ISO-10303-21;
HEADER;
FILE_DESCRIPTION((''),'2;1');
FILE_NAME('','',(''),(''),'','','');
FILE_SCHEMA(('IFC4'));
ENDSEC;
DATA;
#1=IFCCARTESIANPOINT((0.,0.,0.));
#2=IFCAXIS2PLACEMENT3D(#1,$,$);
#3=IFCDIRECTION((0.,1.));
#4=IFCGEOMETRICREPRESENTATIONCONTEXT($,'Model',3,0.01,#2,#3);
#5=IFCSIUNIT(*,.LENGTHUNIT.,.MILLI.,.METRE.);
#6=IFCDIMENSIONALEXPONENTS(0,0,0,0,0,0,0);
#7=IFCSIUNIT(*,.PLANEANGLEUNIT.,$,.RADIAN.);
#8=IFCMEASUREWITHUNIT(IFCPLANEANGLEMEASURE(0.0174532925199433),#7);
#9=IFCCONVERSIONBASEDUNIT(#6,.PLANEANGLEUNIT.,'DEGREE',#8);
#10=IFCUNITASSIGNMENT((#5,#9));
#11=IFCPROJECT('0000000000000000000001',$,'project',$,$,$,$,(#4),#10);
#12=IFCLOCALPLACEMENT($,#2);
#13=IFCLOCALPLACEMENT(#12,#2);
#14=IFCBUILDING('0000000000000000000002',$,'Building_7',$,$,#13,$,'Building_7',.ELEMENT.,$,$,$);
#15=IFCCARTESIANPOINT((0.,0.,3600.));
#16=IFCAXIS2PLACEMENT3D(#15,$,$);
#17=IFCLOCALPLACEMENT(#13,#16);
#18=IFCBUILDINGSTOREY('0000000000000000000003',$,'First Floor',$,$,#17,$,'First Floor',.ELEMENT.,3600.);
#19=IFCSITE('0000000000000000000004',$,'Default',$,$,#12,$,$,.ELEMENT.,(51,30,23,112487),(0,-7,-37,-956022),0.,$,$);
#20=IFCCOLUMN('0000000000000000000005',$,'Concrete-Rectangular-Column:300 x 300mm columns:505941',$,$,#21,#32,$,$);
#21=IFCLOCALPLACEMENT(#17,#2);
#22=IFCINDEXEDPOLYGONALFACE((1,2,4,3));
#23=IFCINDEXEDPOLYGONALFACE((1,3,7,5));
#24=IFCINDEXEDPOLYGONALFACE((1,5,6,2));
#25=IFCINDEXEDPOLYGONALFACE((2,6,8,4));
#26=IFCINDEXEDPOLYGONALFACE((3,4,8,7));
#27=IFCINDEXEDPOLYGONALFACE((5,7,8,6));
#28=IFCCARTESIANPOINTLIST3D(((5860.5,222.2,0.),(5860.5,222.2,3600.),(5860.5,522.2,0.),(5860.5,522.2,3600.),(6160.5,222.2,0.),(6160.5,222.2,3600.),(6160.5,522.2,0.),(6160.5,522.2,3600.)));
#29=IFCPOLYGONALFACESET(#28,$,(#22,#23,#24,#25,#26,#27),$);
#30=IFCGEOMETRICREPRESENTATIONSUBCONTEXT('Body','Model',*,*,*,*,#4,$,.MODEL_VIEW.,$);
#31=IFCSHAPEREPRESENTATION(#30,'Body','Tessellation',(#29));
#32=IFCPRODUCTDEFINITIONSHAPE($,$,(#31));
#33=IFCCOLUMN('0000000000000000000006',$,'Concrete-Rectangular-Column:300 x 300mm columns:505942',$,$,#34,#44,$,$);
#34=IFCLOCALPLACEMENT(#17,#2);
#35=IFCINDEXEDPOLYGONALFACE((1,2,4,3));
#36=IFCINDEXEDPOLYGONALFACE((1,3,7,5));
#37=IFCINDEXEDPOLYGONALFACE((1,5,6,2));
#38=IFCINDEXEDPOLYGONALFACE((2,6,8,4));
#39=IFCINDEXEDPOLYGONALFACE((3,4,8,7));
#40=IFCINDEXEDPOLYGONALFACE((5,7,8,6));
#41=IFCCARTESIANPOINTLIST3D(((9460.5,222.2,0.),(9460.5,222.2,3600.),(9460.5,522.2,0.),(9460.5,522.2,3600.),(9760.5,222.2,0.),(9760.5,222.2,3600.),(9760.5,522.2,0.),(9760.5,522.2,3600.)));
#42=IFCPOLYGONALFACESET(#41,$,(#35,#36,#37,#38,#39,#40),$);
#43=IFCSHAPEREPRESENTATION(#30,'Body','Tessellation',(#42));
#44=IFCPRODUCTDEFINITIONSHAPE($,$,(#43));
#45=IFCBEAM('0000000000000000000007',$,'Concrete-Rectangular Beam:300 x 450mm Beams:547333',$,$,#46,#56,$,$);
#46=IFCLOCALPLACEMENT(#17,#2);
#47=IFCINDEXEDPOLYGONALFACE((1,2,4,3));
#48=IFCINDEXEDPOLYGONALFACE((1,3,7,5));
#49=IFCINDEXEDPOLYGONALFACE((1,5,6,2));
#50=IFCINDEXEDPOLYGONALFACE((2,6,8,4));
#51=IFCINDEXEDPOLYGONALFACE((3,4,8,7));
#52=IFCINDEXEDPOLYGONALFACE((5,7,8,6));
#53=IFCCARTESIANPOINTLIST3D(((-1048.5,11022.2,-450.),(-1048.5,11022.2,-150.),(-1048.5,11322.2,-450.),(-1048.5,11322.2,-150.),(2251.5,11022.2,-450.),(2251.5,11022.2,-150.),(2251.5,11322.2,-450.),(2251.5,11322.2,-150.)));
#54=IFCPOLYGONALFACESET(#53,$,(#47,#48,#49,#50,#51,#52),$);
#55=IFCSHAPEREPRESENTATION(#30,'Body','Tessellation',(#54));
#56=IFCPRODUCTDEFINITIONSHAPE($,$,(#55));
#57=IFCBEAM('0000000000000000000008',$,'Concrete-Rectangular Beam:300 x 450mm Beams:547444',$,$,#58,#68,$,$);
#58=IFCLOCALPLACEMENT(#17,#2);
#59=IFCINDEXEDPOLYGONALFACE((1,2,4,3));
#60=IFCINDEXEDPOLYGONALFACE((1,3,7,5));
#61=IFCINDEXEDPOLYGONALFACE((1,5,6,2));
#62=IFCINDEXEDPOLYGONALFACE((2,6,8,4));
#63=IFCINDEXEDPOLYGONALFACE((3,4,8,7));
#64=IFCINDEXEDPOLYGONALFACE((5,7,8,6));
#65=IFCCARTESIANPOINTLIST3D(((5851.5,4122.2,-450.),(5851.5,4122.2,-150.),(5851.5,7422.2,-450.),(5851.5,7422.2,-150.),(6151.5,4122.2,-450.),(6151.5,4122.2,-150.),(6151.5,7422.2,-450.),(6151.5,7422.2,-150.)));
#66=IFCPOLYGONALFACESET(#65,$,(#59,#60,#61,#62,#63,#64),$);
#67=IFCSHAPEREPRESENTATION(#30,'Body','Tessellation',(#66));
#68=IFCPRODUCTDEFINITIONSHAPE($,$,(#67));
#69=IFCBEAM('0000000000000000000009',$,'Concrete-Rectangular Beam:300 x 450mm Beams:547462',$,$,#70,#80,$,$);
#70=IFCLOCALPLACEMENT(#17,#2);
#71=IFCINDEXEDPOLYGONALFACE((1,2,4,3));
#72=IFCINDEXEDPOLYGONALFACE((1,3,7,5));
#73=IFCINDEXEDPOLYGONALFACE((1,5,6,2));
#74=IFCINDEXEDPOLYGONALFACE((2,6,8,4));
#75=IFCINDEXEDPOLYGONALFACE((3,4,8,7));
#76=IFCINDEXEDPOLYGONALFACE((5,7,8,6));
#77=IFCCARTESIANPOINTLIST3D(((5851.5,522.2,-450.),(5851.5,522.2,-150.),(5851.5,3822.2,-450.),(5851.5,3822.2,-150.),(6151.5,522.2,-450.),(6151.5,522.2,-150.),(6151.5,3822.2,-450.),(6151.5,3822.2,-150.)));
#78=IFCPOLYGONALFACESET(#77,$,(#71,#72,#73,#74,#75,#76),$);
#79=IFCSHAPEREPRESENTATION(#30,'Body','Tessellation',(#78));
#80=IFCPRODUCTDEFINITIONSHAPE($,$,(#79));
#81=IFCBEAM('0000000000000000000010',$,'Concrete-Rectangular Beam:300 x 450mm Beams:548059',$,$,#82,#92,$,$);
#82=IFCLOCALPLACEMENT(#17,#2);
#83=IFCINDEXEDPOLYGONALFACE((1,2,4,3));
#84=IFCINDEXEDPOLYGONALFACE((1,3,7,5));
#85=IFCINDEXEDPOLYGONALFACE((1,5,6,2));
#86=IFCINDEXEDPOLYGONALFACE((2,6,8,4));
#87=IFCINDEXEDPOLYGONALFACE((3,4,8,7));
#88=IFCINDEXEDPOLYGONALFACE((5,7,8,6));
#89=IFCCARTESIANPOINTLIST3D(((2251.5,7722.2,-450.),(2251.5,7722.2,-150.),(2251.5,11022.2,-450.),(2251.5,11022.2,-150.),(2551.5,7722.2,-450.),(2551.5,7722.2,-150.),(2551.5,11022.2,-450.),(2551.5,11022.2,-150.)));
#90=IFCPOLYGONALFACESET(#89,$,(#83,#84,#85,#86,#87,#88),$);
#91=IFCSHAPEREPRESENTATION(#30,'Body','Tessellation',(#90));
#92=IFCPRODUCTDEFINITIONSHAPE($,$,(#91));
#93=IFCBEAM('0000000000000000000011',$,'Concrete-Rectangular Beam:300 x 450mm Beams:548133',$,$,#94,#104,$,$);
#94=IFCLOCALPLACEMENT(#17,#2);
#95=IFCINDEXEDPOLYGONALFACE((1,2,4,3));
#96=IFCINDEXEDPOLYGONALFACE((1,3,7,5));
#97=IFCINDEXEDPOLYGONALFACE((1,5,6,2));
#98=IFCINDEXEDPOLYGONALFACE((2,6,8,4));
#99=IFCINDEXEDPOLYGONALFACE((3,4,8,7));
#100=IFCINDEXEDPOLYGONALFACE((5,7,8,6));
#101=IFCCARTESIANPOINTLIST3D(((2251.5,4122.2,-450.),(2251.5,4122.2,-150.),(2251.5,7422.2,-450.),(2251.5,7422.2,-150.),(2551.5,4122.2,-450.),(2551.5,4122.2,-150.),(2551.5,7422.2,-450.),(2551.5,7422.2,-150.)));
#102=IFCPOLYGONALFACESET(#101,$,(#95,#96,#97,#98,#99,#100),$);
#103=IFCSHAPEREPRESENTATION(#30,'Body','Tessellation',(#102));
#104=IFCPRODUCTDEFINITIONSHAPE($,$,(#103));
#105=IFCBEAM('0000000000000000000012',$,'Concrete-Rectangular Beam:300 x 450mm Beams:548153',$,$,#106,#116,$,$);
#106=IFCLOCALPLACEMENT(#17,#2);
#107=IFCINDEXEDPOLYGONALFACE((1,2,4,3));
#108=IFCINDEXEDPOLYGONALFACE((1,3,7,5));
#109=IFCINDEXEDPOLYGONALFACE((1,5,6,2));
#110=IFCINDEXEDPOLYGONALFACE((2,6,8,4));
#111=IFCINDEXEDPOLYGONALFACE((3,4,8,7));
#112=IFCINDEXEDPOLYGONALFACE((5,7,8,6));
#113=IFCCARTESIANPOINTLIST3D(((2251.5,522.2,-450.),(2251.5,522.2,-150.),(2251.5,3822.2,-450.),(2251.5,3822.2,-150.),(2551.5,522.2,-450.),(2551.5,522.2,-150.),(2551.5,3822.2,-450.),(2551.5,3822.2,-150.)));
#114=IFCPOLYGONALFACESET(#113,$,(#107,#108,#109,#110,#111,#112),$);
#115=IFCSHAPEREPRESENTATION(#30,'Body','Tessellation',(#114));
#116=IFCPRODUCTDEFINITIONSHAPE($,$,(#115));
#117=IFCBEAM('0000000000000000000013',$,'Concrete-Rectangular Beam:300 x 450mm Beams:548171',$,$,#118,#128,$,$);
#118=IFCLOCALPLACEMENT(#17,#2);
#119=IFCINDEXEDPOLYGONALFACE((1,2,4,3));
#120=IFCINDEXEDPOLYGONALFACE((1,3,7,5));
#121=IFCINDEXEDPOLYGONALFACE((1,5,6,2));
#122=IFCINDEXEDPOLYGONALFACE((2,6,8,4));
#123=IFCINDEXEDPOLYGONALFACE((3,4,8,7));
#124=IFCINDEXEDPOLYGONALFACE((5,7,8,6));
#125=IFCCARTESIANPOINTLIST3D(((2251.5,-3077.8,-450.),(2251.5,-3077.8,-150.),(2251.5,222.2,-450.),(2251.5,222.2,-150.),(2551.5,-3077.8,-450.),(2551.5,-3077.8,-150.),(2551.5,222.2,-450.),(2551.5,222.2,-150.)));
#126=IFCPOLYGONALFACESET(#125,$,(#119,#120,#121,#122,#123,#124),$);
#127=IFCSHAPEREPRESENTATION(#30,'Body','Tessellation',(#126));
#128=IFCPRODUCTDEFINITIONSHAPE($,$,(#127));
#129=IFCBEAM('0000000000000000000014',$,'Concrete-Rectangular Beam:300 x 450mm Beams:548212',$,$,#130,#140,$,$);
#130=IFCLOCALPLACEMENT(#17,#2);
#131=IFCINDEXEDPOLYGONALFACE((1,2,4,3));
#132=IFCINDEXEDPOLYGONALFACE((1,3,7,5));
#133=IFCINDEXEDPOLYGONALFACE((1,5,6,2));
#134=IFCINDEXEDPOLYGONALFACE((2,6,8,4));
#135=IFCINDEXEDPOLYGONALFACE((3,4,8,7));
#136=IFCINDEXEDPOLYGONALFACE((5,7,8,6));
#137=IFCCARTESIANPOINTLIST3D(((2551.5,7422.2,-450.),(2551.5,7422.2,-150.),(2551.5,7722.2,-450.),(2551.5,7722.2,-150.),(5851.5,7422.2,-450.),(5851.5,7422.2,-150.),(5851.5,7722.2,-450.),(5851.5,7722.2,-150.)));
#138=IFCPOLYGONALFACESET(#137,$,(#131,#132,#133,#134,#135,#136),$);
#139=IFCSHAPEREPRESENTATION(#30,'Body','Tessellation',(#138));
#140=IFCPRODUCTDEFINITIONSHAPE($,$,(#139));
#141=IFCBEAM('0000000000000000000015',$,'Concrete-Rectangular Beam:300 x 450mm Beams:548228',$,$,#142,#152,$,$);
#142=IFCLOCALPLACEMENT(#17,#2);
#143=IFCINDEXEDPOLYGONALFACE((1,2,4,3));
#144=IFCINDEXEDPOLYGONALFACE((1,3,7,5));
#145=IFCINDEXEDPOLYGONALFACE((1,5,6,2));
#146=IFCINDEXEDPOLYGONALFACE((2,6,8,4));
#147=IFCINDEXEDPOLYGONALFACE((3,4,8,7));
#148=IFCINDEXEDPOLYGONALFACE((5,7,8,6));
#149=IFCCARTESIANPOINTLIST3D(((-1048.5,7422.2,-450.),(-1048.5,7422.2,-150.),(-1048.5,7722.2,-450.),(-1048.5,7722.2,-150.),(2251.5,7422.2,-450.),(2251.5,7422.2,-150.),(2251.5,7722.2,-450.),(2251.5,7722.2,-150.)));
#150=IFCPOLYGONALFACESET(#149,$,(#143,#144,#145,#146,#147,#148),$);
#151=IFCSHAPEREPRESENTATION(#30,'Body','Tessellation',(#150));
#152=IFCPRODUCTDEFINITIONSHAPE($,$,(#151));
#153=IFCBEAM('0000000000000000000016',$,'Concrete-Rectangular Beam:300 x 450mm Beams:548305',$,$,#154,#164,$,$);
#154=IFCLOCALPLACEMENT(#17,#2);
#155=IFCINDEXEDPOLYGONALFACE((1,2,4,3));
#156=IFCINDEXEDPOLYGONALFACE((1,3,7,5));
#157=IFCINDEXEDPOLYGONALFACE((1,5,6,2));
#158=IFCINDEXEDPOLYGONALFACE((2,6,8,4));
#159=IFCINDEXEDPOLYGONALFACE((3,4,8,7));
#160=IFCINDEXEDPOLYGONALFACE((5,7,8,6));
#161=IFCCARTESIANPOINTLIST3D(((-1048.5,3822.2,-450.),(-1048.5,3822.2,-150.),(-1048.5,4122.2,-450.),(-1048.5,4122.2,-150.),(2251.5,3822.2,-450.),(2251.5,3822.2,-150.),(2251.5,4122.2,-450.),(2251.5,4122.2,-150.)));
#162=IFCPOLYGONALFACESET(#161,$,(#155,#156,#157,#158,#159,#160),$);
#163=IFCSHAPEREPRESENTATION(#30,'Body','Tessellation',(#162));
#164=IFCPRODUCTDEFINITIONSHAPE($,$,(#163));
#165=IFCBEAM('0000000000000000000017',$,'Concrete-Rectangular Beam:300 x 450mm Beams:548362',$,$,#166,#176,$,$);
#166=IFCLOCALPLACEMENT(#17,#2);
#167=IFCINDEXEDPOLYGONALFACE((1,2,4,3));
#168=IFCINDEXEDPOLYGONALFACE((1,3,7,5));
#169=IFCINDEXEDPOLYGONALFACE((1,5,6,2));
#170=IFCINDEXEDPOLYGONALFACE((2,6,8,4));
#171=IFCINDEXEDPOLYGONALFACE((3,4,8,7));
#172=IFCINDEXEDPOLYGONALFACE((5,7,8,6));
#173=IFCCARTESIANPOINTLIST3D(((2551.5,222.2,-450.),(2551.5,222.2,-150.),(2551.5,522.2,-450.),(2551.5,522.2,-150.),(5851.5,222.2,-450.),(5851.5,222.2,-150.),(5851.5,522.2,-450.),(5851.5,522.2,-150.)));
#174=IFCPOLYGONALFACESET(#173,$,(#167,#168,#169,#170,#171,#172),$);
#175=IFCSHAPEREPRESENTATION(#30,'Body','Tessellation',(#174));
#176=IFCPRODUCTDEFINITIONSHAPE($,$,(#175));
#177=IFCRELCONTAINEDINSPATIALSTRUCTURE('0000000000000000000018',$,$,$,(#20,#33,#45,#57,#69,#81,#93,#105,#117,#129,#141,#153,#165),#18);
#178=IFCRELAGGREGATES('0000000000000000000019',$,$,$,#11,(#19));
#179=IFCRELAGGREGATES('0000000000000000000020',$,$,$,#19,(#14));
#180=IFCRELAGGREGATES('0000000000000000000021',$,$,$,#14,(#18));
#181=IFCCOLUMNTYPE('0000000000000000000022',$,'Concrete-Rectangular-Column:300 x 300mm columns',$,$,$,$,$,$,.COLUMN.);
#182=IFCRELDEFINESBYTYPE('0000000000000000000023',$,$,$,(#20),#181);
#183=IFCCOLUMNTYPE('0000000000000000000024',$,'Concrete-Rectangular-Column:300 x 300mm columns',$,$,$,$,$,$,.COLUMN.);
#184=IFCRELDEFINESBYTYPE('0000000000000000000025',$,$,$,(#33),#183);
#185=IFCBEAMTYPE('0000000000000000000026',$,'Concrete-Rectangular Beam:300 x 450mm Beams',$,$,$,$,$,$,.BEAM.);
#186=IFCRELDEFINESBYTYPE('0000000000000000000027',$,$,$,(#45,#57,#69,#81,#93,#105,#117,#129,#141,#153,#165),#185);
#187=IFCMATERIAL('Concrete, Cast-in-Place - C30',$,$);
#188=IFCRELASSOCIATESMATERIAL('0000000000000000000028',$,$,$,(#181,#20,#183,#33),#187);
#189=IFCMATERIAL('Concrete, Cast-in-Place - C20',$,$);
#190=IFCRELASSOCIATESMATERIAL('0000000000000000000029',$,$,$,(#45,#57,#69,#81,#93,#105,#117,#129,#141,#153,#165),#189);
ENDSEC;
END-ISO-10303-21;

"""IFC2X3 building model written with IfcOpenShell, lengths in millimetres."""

from ifc_helpers import new_model, entity, si_unit, converted_unit, direction, frame, frame_2d, origin, origin_2d_with_axis, place, context, subcontext, project, spatial, rectangle, extrude, source, transform, mapped, material, type_object, type_shapes, element, save


model = new_model("IFC2X3")

# Units and contexts
model_context = context("Model", 3, precision=0.01, world=origin(), true_north=direction((0.0, 1.0)))
body_context = subcontext(model_context, "Body", "Model", "MODEL_VIEW")
ifc_project = project(units=[si_unit("LENGTHUNIT", "METRE", prefix="MILLI"), converted_unit("PLANEANGLEUNIT", "DEGREE", entity("IfcPlaneAngleMeasure", 0.0174532925199433), si_unit("PLANEANGLEUNIT", "RADIAN"), dimensions=[0, 0, 0, 0, 0, 0, 0])], contexts=[model_context])

# Site, building, storey
site_placement = place(None, origin())
site = spatial("IfcSite", under=ifc_project, at=site_placement, Name="Default", CompositionType="ELEMENT", RefLatitude=(51, 30, 23, 112487), RefLongitude=(0, -7, -37, -956022), RefElevation=0.0)
building_placement = place(site_placement, origin())
building = spatial("IfcBuilding", under=site, at=building_placement, Name="Building_7", LongName="Building_7", CompositionType="ELEMENT")
storey_placement = place(building_placement, frame((0.0, 0.0, 3600.0)))
storey = spatial("IfcBuildingStorey", under=building, at=storey_placement, Name="First Floor", LongName="First Floor", CompositionType="ELEMENT", Elevation=3600.0)

# Shared definitions
ifc_material_1 = material(Name="Concrete, Cast-in-Place - C30")

# Columns
column_type_1 = type_object("IfcColumnType", Name="Concrete-Rectangular-Column:300 x 300mm columns", PredefinedType="COLUMN", material=ifc_material_1)
shared_shape_1 = source(origin(), body_context, "Body", "SweptSolid", [
    extrude(rectangle(XDim=300.0, YDim=300.0, at=frame_2d((0.0, 0.0), x_axis=(1.0, 0.0))), frame((6010.5, 372.2, 3600.0), z_axis=(0.0, 0.0, 1.0), x_axis=(-1.0, 0.0, 0.0)), (0.0, 0.0, 1.0), 3600.0),
])
type_shapes(column_type_1, [shared_shape_1])
column_1_placement = place(storey_placement, frame((0.0, 0.0, -3600.0)))
element("IfcColumn", 1, at=column_1_placement, inside=storey, type_object=column_type_1, material=ifc_material_1, Name="Concrete-Rectangular-Column:300 x 300mm columns:505941", context=body_context, shape_type="MappedRepresentation", body=[
    mapped(shared_shape_1, transform((0.0, 0.0, 0.0), scale=1.0)),
])
column_type_2 = type_object("IfcColumnType", Name="Concrete-Rectangular-Column:300 x 300mm columns", PredefinedType="COLUMN", material=ifc_material_1)
shared_shape_2 = source(origin(), body_context, "Body", "SweptSolid", [
    extrude(rectangle(XDim=300.0, YDim=300.0, at=frame_2d((0.0, 0.0), x_axis=(1.0, 0.0))), frame((9610.5, 372.2, 3600.0), z_axis=(0.0, 0.0, 1.0), x_axis=(-1.0, 0.0, 0.0)), (0.0, 0.0, 1.0), 3600.0),
])
type_shapes(column_type_2, [shared_shape_2])
column_2_placement = place(storey_placement, frame((0.0, 0.0, -3600.0)))
element("IfcColumn", 2, at=column_2_placement, inside=storey, type_object=column_type_2, material=ifc_material_1, Name="Concrete-Rectangular-Column:300 x 300mm columns:505942", context=body_context, shape_type="MappedRepresentation", body=[
    mapped(shared_shape_2, transform((0.0, 0.0, 0.0), scale=1.0)),
])

# Beams
ifc_material_2 = material(Name="Concrete, Cast-in-Place - C20")
beam_type_1 = type_object("IfcBeamType", Name="Concrete-Rectangular Beam:300 x 450mm Beams", PredefinedType="BEAM")
beam_1_placement = place(storey_placement, frame((2401.5, 11172.2, 0.0), z_axis=(0.0, 0.0, 1.0), x_axis=(-1.0, 0.0, 0.0)))
element("IfcBeam", 3, at=beam_1_placement, inside=storey, type_object=beam_type_1, material=ifc_material_2, Name="Concrete-Rectangular Beam:300 x 450mm Beams:547333", context=body_context, shape_type="SweptSolid", body=[
    extrude(rectangle(XDim=300.0, YDim=300.0, at=frame_2d((0.0, 0.0), x_axis=(1.0, 0.0))), frame((150.0, 0.0, -300.0), z_axis=(1.0, 0.0, 0.0), x_axis=(0.0, 0.0, -1.0)), (0.0, 0.0, 1.0), 3300.0),
])
beam_2_placement = place(storey_placement, frame((6001.5, 7572.2, 0.0), z_axis=(0.0, 0.0, 1.0), x_axis=(0.0, -1.0, 0.0)))
element("IfcBeam", 4, at=beam_2_placement, inside=storey, type_object=beam_type_1, material=ifc_material_2, Name="Concrete-Rectangular Beam:300 x 450mm Beams:547444", context=body_context, shape_type="SweptSolid", body=[
    extrude(rectangle(XDim=300.0, YDim=300.0, at=origin_2d_with_axis()), frame((150.0, 0.0, -300.0), z_axis=(1.0, 0.0, 0.0), x_axis=(0.0, 0.0, -1.0)), (0.0, 0.0, 1.0), 3300.0),
])
beam_3_placement = place(storey_placement, frame((6001.5, 3972.2, 0.0), z_axis=(0.0, 0.0, 1.0), x_axis=(0.0, -1.0, 0.0)))
element("IfcBeam", 5, at=beam_3_placement, inside=storey, type_object=beam_type_1, material=ifc_material_2, Name="Concrete-Rectangular Beam:300 x 450mm Beams:547462", context=body_context, shape_type="SweptSolid", body=[
    extrude(rectangle(XDim=300.0, YDim=300.0, at=origin_2d_with_axis()), frame((150.0, 0.0, -300.0), z_axis=(1.0, 0.0, 0.0), x_axis=(0.0, 0.0, -1.0)), (0.0, 0.0, 1.0), 3300.0),
])
beam_4_placement = place(storey_placement, frame((2401.5, 11172.2, 0.0), z_axis=(0.0, 0.0, 1.0), x_axis=(0.0, -1.0, 0.0)))
element("IfcBeam", 6, at=beam_4_placement, inside=storey, type_object=beam_type_1, material=ifc_material_2, Name="Concrete-Rectangular Beam:300 x 450mm Beams:548059", context=body_context, shape_type="SweptSolid", body=[
    extrude(rectangle(XDim=300.0, YDim=300.0, at=origin_2d_with_axis()), frame((150.0, 0.0, -300.0), z_axis=(1.0, 0.0, 0.0), x_axis=(0.0, 0.0, -1.0)), (0.0, 0.0, 1.0), 3300.0),
])
beam_5_placement = place(storey_placement, frame((2401.5, 7572.2, 0.0), z_axis=(0.0, 0.0, 1.0), x_axis=(0.0, -1.0, 0.0)))
element("IfcBeam", 7, at=beam_5_placement, inside=storey, type_object=beam_type_1, material=ifc_material_2, Name="Concrete-Rectangular Beam:300 x 450mm Beams:548133", context=body_context, shape_type="SweptSolid", body=[
    extrude(rectangle(XDim=300.0, YDim=300.0, at=frame_2d((0.0, 0.0), x_axis=(1.0, 0.0))), frame((150.0, 0.0, -300.0), z_axis=(1.0, 0.0, 0.0), x_axis=(0.0, 0.0, -1.0)), (0.0, 0.0, 1.0), 3300.0),
])
beam_6_placement = place(storey_placement, frame((2401.5, 3972.2, 0.0), z_axis=(0.0, 0.0, 1.0), x_axis=(0.0, -1.0, 0.0)))
element("IfcBeam", 8, at=beam_6_placement, inside=storey, type_object=beam_type_1, material=ifc_material_2, Name="Concrete-Rectangular Beam:300 x 450mm Beams:548153", context=body_context, shape_type="SweptSolid", body=[
    extrude(rectangle(XDim=300.0, YDim=300.0, at=frame_2d((0.0, 0.0), x_axis=(1.0, 0.0))), frame((150.0, 0.0, -300.0), z_axis=(1.0, 0.0, 0.0), x_axis=(0.0, 0.0, -1.0)), (0.0, 0.0, 1.0), 3300.0),
])
beam_7_placement = place(storey_placement, frame((2401.5, 372.2, 0.0), z_axis=(0.0, 0.0, 1.0), x_axis=(0.0, -1.0, 0.0)))
element("IfcBeam", 9, at=beam_7_placement, inside=storey, type_object=beam_type_1, material=ifc_material_2, Name="Concrete-Rectangular Beam:300 x 450mm Beams:548171", context=body_context, shape_type="SweptSolid", body=[
    extrude(rectangle(XDim=300.0, YDim=300.0, at=frame_2d((0.0, 0.0), x_axis=(1.0, 0.0))), frame((150.0, 0.0, -300.0), z_axis=(1.0, 0.0, 0.0), x_axis=(0.0, 0.0, -1.0)), (0.0, 0.0, 1.0), 3300.0),
])
beam_8_placement = place(storey_placement, frame((6001.5, 7572.2, 0.0), z_axis=(0.0, 0.0, 1.0), x_axis=(-1.0, 0.0, 0.0)))
element("IfcBeam", 10, at=beam_8_placement, inside=storey, type_object=beam_type_1, material=ifc_material_2, Name="Concrete-Rectangular Beam:300 x 450mm Beams:548212", context=body_context, shape_type="SweptSolid", body=[
    extrude(rectangle(XDim=300.0, YDim=300.0, at=frame_2d((0.0, 0.0), x_axis=(1.0, 0.0))), frame((150.0, 0.0, -300.0), z_axis=(1.0, 0.0, 0.0), x_axis=(0.0, 0.0, -1.0)), (0.0, 0.0, 1.0), 3300.0),
])
beam_9_placement = place(storey_placement, frame((2401.5, 7572.2, 0.0), z_axis=(0.0, 0.0, 1.0), x_axis=(-1.0, 0.0, 0.0)))
element("IfcBeam", 11, at=beam_9_placement, inside=storey, type_object=beam_type_1, material=ifc_material_2, Name="Concrete-Rectangular Beam:300 x 450mm Beams:548228", context=body_context, shape_type="SweptSolid", body=[
    extrude(rectangle(XDim=300.0, YDim=300.0, at=frame_2d((0.0, 0.0), x_axis=(1.0, 0.0))), frame((150.0, 0.0, -300.0), z_axis=(1.0, 0.0, 0.0), x_axis=(0.0, 0.0, -1.0)), (0.0, 0.0, 1.0), 3300.0),
])
beam_10_placement = place(storey_placement, frame((2401.5, 3972.2, 0.0), z_axis=(0.0, 0.0, 1.0), x_axis=(-1.0, 0.0, 0.0)))
element("IfcBeam", 12, at=beam_10_placement, inside=storey, type_object=beam_type_1, material=ifc_material_2, Name="Concrete-Rectangular Beam:300 x 450mm Beams:548305", context=body_context, shape_type="SweptSolid", body=[
    extrude(rectangle(XDim=300.0, YDim=300.0, at=frame_2d((0.0, 0.0), x_axis=(1.0, 0.0))), frame((150.0, 0.0, -300.0), z_axis=(1.0, 0.0, 0.0), x_axis=(0.0, 0.0, -1.0)), (0.0, 0.0, 1.0), 3300.0),
])
beam_11_placement = place(storey_placement, frame((6001.5, 372.2, 0.0), z_axis=(0.0, 0.0, 1.0), x_axis=(-1.0, 0.0, 0.0)))
element("IfcBeam", 13, at=beam_11_placement, inside=storey, type_object=beam_type_1, material=ifc_material_2, Name="Concrete-Rectangular Beam:300 x 450mm Beams:548362", context=body_context, shape_type="SweptSolid", body=[
    extrude(rectangle(XDim=300.0, YDim=300.0, at=frame_2d((0.0, 0.0), x_axis=(1.0, 0.0))), frame((150.0, 0.0, -300.0), z_axis=(1.0, 0.0, 0.0), x_axis=(0.0, 0.0, -1.0)), (0.0, 0.0, 1.0), 3300.0),
])

save(model, "model.ifc")
